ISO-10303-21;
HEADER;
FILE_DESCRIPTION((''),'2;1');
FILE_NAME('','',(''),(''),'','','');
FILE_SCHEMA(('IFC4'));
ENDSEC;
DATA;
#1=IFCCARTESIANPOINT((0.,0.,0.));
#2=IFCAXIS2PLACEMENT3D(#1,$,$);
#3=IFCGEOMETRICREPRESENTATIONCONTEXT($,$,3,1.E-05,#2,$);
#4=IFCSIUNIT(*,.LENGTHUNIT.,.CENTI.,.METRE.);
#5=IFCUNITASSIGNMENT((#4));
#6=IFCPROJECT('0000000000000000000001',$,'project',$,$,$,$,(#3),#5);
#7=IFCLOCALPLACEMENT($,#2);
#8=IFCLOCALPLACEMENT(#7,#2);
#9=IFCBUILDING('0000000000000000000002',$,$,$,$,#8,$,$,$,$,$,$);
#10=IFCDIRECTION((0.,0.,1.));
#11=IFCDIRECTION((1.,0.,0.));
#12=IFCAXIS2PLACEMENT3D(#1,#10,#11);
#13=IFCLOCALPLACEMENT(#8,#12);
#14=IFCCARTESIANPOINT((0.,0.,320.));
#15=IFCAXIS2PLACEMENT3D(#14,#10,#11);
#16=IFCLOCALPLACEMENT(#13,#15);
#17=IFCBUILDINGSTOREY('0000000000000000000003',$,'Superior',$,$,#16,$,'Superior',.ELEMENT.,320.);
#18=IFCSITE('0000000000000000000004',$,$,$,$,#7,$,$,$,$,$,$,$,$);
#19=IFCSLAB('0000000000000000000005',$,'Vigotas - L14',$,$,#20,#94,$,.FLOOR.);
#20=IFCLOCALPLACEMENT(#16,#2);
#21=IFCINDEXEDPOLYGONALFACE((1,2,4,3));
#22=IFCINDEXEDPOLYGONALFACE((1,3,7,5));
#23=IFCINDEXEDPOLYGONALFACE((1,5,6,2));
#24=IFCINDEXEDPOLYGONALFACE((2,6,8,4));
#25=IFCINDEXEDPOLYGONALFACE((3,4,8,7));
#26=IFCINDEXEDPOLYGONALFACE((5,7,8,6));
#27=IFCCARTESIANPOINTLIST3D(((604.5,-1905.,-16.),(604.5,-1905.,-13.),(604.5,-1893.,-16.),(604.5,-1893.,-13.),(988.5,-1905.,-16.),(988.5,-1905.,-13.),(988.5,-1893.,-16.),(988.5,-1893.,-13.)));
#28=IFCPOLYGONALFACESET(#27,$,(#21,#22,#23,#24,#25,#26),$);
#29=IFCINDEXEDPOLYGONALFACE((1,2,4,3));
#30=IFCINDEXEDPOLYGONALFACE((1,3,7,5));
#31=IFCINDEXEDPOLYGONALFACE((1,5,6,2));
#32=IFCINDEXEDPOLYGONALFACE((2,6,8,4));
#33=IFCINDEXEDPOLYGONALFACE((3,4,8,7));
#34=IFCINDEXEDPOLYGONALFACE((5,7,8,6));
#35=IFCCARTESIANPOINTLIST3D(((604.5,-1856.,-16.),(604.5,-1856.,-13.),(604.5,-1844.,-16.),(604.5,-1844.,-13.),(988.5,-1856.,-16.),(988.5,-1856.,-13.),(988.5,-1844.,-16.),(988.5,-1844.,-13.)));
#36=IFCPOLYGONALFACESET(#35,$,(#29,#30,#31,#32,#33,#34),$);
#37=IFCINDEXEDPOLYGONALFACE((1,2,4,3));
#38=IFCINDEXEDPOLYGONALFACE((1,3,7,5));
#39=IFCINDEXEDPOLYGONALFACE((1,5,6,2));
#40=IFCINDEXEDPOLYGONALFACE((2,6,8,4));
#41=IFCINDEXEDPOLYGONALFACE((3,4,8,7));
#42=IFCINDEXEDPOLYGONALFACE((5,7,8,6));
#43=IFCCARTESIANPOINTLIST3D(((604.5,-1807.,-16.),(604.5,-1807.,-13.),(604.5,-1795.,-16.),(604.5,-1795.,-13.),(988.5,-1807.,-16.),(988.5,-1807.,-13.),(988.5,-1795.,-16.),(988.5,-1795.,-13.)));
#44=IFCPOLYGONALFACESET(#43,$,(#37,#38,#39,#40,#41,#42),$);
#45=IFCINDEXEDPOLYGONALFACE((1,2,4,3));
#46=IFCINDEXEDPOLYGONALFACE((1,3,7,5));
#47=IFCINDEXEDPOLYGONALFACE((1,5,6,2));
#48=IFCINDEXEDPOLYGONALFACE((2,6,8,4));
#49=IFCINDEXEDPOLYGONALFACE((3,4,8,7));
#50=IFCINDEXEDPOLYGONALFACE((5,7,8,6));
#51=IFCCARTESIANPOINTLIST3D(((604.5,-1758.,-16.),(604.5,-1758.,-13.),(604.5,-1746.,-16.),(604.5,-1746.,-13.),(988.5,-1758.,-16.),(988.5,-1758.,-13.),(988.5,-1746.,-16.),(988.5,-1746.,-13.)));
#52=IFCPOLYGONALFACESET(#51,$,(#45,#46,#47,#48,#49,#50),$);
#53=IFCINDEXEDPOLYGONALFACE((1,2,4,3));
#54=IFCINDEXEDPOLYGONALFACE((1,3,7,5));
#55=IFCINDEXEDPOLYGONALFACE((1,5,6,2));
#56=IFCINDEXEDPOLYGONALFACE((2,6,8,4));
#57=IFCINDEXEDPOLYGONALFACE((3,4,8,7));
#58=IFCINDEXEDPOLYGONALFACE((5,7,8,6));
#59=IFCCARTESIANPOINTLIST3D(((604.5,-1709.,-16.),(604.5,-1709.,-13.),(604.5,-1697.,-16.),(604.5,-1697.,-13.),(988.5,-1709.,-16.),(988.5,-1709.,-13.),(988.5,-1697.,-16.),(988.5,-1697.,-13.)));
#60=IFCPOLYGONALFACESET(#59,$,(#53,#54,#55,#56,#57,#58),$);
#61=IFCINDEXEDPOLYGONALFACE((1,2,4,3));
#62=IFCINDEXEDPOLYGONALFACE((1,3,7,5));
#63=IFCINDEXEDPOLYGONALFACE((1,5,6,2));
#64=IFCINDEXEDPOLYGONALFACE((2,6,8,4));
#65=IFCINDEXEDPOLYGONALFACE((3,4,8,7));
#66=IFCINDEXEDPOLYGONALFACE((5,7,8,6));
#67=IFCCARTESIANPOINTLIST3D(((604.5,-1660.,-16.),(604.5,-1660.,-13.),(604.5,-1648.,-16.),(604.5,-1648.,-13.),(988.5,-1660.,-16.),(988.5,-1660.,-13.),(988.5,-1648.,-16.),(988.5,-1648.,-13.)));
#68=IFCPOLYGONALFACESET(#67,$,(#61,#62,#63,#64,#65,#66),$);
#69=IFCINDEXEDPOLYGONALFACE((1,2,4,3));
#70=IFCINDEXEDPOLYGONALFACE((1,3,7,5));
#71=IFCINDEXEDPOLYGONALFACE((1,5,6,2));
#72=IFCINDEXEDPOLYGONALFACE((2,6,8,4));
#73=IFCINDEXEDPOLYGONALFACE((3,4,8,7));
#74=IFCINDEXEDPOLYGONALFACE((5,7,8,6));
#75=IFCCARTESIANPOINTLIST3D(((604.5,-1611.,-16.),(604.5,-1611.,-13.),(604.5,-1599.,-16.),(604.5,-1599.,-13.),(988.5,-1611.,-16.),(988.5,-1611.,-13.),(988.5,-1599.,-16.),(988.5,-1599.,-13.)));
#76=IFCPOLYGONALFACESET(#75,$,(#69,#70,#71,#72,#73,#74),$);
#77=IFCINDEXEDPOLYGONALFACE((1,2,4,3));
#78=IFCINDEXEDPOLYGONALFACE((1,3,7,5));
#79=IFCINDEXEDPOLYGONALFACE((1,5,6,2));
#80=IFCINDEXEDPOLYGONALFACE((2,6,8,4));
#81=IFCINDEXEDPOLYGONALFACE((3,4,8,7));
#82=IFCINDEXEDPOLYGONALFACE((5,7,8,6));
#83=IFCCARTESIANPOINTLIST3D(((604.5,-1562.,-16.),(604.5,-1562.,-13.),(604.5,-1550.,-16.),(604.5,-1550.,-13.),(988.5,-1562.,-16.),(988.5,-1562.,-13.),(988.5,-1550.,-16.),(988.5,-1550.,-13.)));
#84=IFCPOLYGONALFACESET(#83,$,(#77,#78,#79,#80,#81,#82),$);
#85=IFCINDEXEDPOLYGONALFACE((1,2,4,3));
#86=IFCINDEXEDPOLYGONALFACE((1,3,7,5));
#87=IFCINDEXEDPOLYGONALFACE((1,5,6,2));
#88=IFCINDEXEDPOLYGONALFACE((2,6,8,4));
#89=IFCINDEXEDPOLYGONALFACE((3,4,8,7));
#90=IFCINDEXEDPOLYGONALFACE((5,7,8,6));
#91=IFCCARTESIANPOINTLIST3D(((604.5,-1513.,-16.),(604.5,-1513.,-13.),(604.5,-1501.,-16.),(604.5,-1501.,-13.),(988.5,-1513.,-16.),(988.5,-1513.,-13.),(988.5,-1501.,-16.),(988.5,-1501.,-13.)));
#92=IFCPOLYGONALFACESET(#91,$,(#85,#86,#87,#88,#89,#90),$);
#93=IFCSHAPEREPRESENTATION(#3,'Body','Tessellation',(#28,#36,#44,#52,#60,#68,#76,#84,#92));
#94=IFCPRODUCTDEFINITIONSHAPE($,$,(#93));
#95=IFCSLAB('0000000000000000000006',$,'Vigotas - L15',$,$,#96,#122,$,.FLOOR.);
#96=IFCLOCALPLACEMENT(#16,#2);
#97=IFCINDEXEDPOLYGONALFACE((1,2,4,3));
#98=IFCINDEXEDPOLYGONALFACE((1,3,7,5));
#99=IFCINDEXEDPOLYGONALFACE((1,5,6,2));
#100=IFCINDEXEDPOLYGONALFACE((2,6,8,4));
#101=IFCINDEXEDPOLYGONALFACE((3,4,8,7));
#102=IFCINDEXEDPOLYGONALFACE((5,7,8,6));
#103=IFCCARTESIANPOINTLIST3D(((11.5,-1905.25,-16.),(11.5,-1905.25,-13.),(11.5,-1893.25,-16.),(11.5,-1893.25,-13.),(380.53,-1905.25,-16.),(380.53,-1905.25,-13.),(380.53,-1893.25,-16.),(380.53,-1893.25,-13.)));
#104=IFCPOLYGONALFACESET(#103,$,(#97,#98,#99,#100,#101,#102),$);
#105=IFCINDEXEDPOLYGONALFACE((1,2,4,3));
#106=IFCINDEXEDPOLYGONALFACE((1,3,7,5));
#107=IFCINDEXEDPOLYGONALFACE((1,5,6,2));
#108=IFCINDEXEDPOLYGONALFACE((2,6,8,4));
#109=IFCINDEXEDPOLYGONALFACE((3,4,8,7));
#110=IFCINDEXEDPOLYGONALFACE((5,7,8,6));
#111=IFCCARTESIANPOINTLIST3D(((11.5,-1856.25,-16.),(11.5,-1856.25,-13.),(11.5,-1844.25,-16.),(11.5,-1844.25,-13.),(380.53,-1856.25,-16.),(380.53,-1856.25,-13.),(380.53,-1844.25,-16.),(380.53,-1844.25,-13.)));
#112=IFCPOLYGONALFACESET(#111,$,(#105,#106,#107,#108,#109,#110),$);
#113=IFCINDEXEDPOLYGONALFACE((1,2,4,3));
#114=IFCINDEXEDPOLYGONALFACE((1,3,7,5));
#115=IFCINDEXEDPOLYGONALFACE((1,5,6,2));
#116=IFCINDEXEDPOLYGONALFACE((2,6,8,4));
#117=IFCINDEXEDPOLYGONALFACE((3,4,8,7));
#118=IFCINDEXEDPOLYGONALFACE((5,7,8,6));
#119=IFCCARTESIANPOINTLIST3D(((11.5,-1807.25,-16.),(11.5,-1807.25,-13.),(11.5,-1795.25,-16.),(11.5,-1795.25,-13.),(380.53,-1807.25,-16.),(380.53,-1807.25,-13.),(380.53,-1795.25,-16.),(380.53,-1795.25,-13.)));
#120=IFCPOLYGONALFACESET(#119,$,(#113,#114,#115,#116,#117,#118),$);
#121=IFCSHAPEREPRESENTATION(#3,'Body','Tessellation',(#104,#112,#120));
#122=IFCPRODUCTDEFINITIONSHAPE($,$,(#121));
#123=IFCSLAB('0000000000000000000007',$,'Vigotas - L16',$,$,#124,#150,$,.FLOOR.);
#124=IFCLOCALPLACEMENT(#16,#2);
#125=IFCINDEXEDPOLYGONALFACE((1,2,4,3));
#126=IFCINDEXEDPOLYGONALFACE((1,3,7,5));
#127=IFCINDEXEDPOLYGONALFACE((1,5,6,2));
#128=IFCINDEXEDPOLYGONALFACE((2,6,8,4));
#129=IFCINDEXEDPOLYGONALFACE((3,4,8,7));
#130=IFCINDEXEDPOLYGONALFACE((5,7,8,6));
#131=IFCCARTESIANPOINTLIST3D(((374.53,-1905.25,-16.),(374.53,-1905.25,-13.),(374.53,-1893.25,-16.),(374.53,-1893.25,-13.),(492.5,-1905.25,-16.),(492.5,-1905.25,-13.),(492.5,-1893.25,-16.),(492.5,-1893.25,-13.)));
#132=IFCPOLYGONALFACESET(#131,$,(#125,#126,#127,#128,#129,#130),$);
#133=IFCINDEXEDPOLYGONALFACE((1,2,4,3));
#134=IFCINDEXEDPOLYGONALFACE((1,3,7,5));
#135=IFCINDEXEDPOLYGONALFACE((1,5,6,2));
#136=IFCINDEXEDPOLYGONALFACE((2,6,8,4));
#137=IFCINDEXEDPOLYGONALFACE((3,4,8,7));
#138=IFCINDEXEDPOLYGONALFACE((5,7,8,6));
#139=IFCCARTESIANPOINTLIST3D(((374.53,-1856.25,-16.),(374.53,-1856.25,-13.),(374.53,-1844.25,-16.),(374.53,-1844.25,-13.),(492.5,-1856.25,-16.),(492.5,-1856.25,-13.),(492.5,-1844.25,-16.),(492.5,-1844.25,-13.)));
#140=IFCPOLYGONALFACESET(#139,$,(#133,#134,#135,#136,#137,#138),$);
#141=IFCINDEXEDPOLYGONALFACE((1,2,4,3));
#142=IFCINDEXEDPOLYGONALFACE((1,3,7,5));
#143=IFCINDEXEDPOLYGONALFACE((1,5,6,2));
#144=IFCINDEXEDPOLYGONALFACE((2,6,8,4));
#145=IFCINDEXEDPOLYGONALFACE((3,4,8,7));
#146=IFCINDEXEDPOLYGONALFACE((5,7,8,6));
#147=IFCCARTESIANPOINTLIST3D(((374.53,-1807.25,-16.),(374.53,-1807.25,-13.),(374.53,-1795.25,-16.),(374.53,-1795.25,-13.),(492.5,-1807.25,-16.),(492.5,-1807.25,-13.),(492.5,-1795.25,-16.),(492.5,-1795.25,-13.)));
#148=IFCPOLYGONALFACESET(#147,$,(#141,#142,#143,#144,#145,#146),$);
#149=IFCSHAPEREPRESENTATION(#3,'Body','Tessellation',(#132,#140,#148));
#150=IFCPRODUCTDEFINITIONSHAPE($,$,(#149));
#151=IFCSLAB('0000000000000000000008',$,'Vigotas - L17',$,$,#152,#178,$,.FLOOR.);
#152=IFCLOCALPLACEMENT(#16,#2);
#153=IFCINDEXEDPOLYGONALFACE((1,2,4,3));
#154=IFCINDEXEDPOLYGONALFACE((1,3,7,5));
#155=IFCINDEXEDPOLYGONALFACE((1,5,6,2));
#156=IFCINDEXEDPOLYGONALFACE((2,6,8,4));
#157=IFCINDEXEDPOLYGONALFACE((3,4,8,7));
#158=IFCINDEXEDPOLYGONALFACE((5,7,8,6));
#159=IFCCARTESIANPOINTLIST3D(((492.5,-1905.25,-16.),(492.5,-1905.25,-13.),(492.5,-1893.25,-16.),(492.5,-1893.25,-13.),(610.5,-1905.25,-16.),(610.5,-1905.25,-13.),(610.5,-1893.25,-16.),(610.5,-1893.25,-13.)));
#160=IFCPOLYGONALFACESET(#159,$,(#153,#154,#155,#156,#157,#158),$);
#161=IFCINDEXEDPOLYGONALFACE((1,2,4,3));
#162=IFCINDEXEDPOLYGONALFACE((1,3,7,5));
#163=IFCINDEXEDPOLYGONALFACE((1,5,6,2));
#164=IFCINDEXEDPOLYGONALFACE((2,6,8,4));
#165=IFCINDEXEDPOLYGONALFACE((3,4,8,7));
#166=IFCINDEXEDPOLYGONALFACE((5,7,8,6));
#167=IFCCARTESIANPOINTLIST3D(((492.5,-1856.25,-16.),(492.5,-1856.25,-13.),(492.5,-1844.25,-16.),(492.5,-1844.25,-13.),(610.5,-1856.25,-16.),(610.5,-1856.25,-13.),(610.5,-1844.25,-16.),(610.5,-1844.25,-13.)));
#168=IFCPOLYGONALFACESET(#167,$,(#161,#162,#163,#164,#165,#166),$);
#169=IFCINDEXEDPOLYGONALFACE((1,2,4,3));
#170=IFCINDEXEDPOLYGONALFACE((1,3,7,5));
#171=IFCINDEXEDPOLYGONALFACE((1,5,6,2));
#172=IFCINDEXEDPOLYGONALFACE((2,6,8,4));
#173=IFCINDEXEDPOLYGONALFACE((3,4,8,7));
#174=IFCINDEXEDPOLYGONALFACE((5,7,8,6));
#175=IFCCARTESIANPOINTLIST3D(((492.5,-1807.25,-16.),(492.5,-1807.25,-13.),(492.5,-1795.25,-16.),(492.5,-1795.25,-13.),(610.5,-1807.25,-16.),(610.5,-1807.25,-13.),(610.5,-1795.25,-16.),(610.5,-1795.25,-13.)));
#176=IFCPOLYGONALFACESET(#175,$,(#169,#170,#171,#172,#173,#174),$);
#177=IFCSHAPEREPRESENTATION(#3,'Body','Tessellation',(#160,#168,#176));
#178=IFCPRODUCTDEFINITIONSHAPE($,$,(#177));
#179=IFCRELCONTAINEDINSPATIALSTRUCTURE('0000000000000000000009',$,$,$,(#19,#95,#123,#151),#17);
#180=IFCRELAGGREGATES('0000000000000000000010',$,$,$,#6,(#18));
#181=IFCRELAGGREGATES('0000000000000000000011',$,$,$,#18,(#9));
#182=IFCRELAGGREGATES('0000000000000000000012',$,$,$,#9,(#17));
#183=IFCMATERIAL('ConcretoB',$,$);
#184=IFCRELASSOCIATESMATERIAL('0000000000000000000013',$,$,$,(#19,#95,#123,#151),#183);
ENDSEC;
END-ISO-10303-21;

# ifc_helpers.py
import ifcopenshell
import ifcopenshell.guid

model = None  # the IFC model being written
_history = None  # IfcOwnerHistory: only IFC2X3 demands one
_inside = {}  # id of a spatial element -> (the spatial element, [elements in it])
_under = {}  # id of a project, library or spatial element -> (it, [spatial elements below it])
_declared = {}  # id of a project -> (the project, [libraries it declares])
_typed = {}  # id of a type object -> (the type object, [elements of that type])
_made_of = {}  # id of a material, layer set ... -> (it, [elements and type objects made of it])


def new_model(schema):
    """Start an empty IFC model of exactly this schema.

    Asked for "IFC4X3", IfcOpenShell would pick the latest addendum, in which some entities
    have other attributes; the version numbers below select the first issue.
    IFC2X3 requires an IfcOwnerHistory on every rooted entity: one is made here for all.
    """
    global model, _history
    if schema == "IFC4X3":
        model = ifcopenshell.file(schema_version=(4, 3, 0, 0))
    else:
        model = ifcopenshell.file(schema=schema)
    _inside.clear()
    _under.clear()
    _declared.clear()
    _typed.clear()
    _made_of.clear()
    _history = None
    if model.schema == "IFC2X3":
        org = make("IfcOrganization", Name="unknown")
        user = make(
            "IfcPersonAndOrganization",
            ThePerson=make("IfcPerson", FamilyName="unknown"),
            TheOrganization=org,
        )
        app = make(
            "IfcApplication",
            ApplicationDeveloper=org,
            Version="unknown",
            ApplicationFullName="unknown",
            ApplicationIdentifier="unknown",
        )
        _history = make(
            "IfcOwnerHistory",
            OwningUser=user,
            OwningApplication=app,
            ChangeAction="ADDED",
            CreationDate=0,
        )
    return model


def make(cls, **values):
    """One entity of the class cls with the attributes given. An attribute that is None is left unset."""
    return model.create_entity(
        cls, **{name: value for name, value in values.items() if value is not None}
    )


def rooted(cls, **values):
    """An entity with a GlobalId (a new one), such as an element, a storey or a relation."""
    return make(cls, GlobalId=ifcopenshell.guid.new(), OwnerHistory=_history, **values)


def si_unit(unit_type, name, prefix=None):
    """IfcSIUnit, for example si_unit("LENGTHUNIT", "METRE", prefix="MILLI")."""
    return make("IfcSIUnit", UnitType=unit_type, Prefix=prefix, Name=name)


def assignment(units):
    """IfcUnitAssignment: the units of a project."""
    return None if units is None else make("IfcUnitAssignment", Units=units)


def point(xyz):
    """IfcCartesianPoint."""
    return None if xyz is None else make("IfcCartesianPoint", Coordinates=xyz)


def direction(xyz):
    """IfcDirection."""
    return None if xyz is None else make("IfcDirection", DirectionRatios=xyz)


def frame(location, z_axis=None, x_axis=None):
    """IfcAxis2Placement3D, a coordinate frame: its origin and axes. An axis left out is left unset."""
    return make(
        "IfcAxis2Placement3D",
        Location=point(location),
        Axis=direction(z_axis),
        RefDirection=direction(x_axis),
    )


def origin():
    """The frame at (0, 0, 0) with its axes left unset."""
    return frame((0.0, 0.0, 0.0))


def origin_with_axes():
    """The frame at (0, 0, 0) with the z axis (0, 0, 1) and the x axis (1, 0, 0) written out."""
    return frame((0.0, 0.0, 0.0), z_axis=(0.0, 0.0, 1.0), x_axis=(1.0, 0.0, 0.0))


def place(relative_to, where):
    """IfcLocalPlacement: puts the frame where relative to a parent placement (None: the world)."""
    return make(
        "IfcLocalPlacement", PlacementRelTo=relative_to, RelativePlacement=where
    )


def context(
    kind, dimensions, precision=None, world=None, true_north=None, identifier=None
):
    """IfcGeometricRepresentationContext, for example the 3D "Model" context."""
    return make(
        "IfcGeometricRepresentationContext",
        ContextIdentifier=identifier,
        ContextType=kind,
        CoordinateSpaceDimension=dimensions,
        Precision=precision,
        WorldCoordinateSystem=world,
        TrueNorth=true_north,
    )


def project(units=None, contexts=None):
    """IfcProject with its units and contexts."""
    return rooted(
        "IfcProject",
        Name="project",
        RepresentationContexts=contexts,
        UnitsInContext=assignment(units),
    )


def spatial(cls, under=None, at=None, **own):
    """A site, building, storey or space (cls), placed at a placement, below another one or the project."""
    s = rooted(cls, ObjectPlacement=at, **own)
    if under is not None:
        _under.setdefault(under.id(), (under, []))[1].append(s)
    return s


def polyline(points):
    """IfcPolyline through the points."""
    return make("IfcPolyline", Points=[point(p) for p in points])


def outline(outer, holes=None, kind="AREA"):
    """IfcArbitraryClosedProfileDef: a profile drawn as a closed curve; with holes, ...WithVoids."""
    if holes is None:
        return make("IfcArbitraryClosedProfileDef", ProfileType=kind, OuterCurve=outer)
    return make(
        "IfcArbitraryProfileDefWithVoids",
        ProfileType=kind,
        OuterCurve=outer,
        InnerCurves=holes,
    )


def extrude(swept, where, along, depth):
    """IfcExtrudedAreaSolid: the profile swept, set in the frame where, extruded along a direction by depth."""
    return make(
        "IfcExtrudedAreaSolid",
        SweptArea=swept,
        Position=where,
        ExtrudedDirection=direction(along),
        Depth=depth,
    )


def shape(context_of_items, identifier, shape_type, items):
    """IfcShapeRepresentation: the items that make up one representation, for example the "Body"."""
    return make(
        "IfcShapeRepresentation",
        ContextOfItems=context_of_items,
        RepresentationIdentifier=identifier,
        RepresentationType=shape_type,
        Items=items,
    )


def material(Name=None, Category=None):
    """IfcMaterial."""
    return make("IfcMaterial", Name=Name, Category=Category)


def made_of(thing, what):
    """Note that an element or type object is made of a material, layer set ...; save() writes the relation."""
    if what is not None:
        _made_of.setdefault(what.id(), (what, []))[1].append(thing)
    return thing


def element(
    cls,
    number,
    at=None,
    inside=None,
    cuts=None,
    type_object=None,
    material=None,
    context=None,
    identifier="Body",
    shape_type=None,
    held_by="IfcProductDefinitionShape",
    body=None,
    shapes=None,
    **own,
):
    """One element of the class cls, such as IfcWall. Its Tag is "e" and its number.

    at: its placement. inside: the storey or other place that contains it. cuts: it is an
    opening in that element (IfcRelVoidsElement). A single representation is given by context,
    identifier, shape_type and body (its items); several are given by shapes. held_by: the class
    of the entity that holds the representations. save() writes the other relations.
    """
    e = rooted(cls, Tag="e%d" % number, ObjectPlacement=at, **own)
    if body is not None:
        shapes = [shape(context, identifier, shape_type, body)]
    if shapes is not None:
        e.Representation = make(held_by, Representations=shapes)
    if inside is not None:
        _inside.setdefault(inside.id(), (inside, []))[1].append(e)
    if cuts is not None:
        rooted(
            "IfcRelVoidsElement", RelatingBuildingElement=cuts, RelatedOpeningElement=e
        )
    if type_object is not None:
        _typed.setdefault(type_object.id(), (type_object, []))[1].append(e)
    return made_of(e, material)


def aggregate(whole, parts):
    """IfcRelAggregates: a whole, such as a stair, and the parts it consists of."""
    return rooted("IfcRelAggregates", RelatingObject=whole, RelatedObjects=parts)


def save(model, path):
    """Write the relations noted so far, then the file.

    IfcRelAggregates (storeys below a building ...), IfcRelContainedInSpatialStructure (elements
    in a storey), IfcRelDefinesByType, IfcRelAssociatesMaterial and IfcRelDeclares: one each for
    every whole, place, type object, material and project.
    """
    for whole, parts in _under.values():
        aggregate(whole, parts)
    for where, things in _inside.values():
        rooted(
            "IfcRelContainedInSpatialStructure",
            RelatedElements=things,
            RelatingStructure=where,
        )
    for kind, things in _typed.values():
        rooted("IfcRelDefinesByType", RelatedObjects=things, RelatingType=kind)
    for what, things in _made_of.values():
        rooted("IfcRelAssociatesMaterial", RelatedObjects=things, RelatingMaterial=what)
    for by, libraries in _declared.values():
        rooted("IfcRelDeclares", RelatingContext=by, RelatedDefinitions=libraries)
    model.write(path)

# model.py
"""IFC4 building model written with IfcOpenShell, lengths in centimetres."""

from ifc_helpers import new_model, si_unit, frame, origin, origin_with_axes, place, context, project, spatial, polyline, outline, extrude, material, element, save


model = new_model("IFC4")

# Units and contexts
context_of_model = context(None, 3, precision=1e-05, world=origin())
ifc_project = project(units=[si_unit("LENGTHUNIT", "METRE", prefix="CENTI")], contexts=[context_of_model])

# Site, building, storey
site_placement = place(None, origin())
site = spatial("IfcSite", under=ifc_project, at=site_placement)
building_placement = place(site_placement, origin())
building = spatial("IfcBuilding", under=site, at=building_placement)
placement = place(building_placement, origin_with_axes())
storey_placement = place(placement, frame((0.0, 0.0, 320.0), z_axis=(0.0, 0.0, 1.0), x_axis=(1.0, 0.0, 0.0)))
storey = spatial("IfcBuildingStorey", under=building, at=storey_placement, Name="Superior", LongName="Superior", CompositionType="ELEMENT", Elevation=320.0)

# Shared definitions
ifc_material = material(Name="ConcretoB")

# Slabs
slab_1_placement = place(storey_placement, frame((796.5, -1703.0, -13.0), z_axis=(0.0, 0.0, 1.0), x_axis=(1.0, 0.0, 0.0)))
element("IfcSlab", 1, at=slab_1_placement, inside=storey, material=ifc_material, Name="Vigotas - L14", PredefinedType="FLOOR", context=context_of_model, shape_type="SolidModel", body=[
    extrude(outline(polyline([(6.0, 1.5), (-6.0, 1.5), (-6.0, -1.5), (6.0, -1.5), (6.0, 1.5), (6.0, 1.5)])), frame((-192.0, -196.0, -1.5), z_axis=(1.0, 0.0, 0.0), x_axis=(0.0, -1.0, 0.0)), (0.0, 0.0, 1.0), 384.0),
    extrude(outline(polyline([(6.0, 1.5), (-6.0, 1.5), (-6.0, -1.5), (6.0, -1.5), (6.0, 1.5), (6.0, 1.5)])), frame((-192.0, -147.0, -1.5), z_axis=(1.0, 0.0, 0.0), x_axis=(0.0, -1.0, 0.0)), (0.0, 0.0, 1.0), 384.0),
    extrude(outline(polyline([(6.0, 1.5), (-6.0, 1.5), (-6.0, -1.5), (6.0, -1.5), (6.0, 1.5), (6.0, 1.5)])), frame((-192.0, -98.0, -1.5), z_axis=(1.0, 0.0, 0.0), x_axis=(0.0, -1.0, 0.0)), (0.0, 0.0, 1.0), 384.0),
    extrude(outline(polyline([(6.0, 1.5), (-6.0, 1.5), (-6.0, -1.5), (6.0, -1.5), (6.0, 1.5), (6.0, 1.5)])), frame((-192.0, -49.0, -1.5), z_axis=(1.0, 0.0, 0.0), x_axis=(0.0, -1.0, 0.0)), (0.0, 0.0, 1.0), 384.0),
    extrude(outline(polyline([(6.0, 1.5), (-6.0, 1.5), (-6.0, -1.5), (6.0, -1.5), (6.0, 1.5), (6.0, 1.5)])), frame((-192.0, 0.0, -1.5), z_axis=(1.0, 0.0, 0.0), x_axis=(0.0, -1.0, 0.0)), (0.0, 0.0, 1.0), 384.0),
    extrude(outline(polyline([(6.0, 1.5), (-6.0, 1.5), (-6.0, -1.5), (6.0, -1.5), (6.0, 1.5), (6.0, 1.5)])), frame((-192.0, 49.0, -1.5), z_axis=(1.0, 0.0, 0.0), x_axis=(0.0, -1.0, 0.0)), (0.0, 0.0, 1.0), 384.0),
    extrude(outline(polyline([(6.0, 1.5), (-6.0, 1.5), (-6.0, -1.5), (6.0, -1.5), (6.0, 1.5), (6.0, 1.5)])), frame((-192.0, 98.0, -1.5), z_axis=(1.0, 0.0, 0.0), x_axis=(0.0, -1.0, 0.0)), (0.0, 0.0, 1.0), 384.0),
    extrude(outline(polyline([(6.0, 1.5), (-6.0, 1.5), (-6.0, -1.5), (6.0, -1.5), (6.0, 1.5), (6.0, 1.5)])), frame((-192.0, 147.0, -1.5), z_axis=(1.0, 0.0, 0.0), x_axis=(0.0, -1.0, 0.0)), (0.0, 0.0, 1.0), 384.0),
    extrude(outline(polyline([(6.0, 1.5), (-6.0, 1.5), (-6.0, -1.5), (6.0, -1.5), (6.0, 1.5), (6.0, 1.5)])), frame((-192.0, 196.0, -1.5), z_axis=(1.0, 0.0, 0.0), x_axis=(0.0, -1.0, 0.0)), (0.0, 0.0, 1.0), 384.0),
])
slab_2_placement = place(storey_placement, frame((196.01, -1850.25, -13.0), z_axis=(0.0, 0.0, 1.0), x_axis=(1.0, 0.0, 0.0)))
element("IfcSlab", 2, at=slab_2_placement, inside=storey, material=ifc_material, Name="Vigotas - L15", PredefinedType="FLOOR", context=context_of_model, shape_type="SolidModel", body=[
    extrude(outline(polyline([(6.0, 1.5), (-6.0, 1.5), (-6.0, -1.5), (6.0, -1.5), (6.0, 1.5), (6.0, 1.5)])), frame((-184.51, -49.0, -1.5), z_axis=(1.0, 0.0, 0.0), x_axis=(0.0, -1.0, 0.0)), (0.0, 0.0, 1.0), 369.03),
    extrude(outline(polyline([(6.0, 1.5), (-6.0, 1.5), (-6.0, -1.5), (6.0, -1.5), (6.0, 1.5), (6.0, 1.5)])), frame((-184.51, 0.0, -1.5), z_axis=(1.0, 0.0, 0.0), x_axis=(0.0, -1.0, 0.0)), (0.0, 0.0, 1.0), 369.03),
    extrude(outline(polyline([(6.0, 1.5), (-6.0, 1.5), (-6.0, -1.5), (6.0, -1.5), (6.0, 1.5), (6.0, 1.5)])), frame((-184.51, 49.0, -1.5), z_axis=(1.0, 0.0, 0.0), x_axis=(0.0, -1.0, 0.0)), (0.0, 0.0, 1.0), 369.03),
])
slab_3_placement = place(storey_placement, frame((433.51, -1850.25, -13.0), z_axis=(0.0, 0.0, 1.0), x_axis=(1.0, 0.0, 0.0)))
element("IfcSlab", 3, at=slab_3_placement, inside=storey, material=ifc_material, Name="Vigotas - L16", PredefinedType="FLOOR", context=context_of_model, shape_type="SolidModel", body=[
    extrude(outline(polyline([(6.0, 1.5), (-6.0, 1.5), (-6.0, -1.5), (6.0, -1.5), (6.0, 1.5), (6.0, 1.5)])), frame((-58.98, -49.0, -1.5), z_axis=(1.0, 0.0, 0.0), x_axis=(0.0, -1.0, 0.0)), (0.0, 0.0, 1.0), 117.97),
    extrude(outline(polyline([(6.0, 1.5), (-6.0, 1.5), (-6.0, -1.5), (6.0, -1.5), (6.0, 1.5), (6.0, 1.5)])), frame((-58.98, 0.0, -1.5), z_axis=(1.0, 0.0, 0.0), x_axis=(0.0, -1.0, 0.0)), (0.0, 0.0, 1.0), 117.97),
    extrude(outline(polyline([(6.0, 1.5), (-6.0, 1.5), (-6.0, -1.5), (6.0, -1.5), (6.0, 1.5), (6.0, 1.5)])), frame((-58.98, 49.0, -1.5), z_axis=(1.0, 0.0, 0.0), x_axis=(0.0, -1.0, 0.0)), (0.0, 0.0, 1.0), 117.97),
])
slab_4_placement = place(storey_placement, frame((551.5, -1850.25, -13.0), z_axis=(0.0, 0.0, 1.0), x_axis=(1.0, 0.0, 0.0)))
element("IfcSlab", 4, at=slab_4_placement, inside=storey, material=ifc_material, Name="Vigotas - L17", PredefinedType="FLOOR", context=context_of_model, shape_type="SolidModel", body=[
    extrude(outline(polyline([(6.0, 1.5), (-6.0, 1.5), (-6.0, -1.5), (6.0, -1.5), (6.0, 1.5), (6.0, 1.5)])), frame((-59.0, -49.0, -1.5), z_axis=(1.0, 0.0, 0.0), x_axis=(0.0, -1.0, 0.0)), (0.0, 0.0, 1.0), 118.0),
    extrude(outline(polyline([(6.0, 1.5), (-6.0, 1.5), (-6.0, -1.5), (6.0, -1.5), (6.0, 1.5), (6.0, 1.5)])), frame((-59.0, 0.0, -1.5), z_axis=(1.0, 0.0, 0.0), x_axis=(0.0, -1.0, 0.0)), (0.0, 0.0, 1.0), 118.0),
    extrude(outline(polyline([(6.0, 1.5), (-6.0, 1.5), (-6.0, -1.5), (6.0, -1.5), (6.0, 1.5), (6.0, 1.5)])), frame((-59.0, 49.0, -1.5), z_axis=(1.0, 0.0, 0.0), x_axis=(0.0, -1.0, 0.0)), (0.0, 0.0, 1.0), 118.0),
])

save(model, "model.ifc")
